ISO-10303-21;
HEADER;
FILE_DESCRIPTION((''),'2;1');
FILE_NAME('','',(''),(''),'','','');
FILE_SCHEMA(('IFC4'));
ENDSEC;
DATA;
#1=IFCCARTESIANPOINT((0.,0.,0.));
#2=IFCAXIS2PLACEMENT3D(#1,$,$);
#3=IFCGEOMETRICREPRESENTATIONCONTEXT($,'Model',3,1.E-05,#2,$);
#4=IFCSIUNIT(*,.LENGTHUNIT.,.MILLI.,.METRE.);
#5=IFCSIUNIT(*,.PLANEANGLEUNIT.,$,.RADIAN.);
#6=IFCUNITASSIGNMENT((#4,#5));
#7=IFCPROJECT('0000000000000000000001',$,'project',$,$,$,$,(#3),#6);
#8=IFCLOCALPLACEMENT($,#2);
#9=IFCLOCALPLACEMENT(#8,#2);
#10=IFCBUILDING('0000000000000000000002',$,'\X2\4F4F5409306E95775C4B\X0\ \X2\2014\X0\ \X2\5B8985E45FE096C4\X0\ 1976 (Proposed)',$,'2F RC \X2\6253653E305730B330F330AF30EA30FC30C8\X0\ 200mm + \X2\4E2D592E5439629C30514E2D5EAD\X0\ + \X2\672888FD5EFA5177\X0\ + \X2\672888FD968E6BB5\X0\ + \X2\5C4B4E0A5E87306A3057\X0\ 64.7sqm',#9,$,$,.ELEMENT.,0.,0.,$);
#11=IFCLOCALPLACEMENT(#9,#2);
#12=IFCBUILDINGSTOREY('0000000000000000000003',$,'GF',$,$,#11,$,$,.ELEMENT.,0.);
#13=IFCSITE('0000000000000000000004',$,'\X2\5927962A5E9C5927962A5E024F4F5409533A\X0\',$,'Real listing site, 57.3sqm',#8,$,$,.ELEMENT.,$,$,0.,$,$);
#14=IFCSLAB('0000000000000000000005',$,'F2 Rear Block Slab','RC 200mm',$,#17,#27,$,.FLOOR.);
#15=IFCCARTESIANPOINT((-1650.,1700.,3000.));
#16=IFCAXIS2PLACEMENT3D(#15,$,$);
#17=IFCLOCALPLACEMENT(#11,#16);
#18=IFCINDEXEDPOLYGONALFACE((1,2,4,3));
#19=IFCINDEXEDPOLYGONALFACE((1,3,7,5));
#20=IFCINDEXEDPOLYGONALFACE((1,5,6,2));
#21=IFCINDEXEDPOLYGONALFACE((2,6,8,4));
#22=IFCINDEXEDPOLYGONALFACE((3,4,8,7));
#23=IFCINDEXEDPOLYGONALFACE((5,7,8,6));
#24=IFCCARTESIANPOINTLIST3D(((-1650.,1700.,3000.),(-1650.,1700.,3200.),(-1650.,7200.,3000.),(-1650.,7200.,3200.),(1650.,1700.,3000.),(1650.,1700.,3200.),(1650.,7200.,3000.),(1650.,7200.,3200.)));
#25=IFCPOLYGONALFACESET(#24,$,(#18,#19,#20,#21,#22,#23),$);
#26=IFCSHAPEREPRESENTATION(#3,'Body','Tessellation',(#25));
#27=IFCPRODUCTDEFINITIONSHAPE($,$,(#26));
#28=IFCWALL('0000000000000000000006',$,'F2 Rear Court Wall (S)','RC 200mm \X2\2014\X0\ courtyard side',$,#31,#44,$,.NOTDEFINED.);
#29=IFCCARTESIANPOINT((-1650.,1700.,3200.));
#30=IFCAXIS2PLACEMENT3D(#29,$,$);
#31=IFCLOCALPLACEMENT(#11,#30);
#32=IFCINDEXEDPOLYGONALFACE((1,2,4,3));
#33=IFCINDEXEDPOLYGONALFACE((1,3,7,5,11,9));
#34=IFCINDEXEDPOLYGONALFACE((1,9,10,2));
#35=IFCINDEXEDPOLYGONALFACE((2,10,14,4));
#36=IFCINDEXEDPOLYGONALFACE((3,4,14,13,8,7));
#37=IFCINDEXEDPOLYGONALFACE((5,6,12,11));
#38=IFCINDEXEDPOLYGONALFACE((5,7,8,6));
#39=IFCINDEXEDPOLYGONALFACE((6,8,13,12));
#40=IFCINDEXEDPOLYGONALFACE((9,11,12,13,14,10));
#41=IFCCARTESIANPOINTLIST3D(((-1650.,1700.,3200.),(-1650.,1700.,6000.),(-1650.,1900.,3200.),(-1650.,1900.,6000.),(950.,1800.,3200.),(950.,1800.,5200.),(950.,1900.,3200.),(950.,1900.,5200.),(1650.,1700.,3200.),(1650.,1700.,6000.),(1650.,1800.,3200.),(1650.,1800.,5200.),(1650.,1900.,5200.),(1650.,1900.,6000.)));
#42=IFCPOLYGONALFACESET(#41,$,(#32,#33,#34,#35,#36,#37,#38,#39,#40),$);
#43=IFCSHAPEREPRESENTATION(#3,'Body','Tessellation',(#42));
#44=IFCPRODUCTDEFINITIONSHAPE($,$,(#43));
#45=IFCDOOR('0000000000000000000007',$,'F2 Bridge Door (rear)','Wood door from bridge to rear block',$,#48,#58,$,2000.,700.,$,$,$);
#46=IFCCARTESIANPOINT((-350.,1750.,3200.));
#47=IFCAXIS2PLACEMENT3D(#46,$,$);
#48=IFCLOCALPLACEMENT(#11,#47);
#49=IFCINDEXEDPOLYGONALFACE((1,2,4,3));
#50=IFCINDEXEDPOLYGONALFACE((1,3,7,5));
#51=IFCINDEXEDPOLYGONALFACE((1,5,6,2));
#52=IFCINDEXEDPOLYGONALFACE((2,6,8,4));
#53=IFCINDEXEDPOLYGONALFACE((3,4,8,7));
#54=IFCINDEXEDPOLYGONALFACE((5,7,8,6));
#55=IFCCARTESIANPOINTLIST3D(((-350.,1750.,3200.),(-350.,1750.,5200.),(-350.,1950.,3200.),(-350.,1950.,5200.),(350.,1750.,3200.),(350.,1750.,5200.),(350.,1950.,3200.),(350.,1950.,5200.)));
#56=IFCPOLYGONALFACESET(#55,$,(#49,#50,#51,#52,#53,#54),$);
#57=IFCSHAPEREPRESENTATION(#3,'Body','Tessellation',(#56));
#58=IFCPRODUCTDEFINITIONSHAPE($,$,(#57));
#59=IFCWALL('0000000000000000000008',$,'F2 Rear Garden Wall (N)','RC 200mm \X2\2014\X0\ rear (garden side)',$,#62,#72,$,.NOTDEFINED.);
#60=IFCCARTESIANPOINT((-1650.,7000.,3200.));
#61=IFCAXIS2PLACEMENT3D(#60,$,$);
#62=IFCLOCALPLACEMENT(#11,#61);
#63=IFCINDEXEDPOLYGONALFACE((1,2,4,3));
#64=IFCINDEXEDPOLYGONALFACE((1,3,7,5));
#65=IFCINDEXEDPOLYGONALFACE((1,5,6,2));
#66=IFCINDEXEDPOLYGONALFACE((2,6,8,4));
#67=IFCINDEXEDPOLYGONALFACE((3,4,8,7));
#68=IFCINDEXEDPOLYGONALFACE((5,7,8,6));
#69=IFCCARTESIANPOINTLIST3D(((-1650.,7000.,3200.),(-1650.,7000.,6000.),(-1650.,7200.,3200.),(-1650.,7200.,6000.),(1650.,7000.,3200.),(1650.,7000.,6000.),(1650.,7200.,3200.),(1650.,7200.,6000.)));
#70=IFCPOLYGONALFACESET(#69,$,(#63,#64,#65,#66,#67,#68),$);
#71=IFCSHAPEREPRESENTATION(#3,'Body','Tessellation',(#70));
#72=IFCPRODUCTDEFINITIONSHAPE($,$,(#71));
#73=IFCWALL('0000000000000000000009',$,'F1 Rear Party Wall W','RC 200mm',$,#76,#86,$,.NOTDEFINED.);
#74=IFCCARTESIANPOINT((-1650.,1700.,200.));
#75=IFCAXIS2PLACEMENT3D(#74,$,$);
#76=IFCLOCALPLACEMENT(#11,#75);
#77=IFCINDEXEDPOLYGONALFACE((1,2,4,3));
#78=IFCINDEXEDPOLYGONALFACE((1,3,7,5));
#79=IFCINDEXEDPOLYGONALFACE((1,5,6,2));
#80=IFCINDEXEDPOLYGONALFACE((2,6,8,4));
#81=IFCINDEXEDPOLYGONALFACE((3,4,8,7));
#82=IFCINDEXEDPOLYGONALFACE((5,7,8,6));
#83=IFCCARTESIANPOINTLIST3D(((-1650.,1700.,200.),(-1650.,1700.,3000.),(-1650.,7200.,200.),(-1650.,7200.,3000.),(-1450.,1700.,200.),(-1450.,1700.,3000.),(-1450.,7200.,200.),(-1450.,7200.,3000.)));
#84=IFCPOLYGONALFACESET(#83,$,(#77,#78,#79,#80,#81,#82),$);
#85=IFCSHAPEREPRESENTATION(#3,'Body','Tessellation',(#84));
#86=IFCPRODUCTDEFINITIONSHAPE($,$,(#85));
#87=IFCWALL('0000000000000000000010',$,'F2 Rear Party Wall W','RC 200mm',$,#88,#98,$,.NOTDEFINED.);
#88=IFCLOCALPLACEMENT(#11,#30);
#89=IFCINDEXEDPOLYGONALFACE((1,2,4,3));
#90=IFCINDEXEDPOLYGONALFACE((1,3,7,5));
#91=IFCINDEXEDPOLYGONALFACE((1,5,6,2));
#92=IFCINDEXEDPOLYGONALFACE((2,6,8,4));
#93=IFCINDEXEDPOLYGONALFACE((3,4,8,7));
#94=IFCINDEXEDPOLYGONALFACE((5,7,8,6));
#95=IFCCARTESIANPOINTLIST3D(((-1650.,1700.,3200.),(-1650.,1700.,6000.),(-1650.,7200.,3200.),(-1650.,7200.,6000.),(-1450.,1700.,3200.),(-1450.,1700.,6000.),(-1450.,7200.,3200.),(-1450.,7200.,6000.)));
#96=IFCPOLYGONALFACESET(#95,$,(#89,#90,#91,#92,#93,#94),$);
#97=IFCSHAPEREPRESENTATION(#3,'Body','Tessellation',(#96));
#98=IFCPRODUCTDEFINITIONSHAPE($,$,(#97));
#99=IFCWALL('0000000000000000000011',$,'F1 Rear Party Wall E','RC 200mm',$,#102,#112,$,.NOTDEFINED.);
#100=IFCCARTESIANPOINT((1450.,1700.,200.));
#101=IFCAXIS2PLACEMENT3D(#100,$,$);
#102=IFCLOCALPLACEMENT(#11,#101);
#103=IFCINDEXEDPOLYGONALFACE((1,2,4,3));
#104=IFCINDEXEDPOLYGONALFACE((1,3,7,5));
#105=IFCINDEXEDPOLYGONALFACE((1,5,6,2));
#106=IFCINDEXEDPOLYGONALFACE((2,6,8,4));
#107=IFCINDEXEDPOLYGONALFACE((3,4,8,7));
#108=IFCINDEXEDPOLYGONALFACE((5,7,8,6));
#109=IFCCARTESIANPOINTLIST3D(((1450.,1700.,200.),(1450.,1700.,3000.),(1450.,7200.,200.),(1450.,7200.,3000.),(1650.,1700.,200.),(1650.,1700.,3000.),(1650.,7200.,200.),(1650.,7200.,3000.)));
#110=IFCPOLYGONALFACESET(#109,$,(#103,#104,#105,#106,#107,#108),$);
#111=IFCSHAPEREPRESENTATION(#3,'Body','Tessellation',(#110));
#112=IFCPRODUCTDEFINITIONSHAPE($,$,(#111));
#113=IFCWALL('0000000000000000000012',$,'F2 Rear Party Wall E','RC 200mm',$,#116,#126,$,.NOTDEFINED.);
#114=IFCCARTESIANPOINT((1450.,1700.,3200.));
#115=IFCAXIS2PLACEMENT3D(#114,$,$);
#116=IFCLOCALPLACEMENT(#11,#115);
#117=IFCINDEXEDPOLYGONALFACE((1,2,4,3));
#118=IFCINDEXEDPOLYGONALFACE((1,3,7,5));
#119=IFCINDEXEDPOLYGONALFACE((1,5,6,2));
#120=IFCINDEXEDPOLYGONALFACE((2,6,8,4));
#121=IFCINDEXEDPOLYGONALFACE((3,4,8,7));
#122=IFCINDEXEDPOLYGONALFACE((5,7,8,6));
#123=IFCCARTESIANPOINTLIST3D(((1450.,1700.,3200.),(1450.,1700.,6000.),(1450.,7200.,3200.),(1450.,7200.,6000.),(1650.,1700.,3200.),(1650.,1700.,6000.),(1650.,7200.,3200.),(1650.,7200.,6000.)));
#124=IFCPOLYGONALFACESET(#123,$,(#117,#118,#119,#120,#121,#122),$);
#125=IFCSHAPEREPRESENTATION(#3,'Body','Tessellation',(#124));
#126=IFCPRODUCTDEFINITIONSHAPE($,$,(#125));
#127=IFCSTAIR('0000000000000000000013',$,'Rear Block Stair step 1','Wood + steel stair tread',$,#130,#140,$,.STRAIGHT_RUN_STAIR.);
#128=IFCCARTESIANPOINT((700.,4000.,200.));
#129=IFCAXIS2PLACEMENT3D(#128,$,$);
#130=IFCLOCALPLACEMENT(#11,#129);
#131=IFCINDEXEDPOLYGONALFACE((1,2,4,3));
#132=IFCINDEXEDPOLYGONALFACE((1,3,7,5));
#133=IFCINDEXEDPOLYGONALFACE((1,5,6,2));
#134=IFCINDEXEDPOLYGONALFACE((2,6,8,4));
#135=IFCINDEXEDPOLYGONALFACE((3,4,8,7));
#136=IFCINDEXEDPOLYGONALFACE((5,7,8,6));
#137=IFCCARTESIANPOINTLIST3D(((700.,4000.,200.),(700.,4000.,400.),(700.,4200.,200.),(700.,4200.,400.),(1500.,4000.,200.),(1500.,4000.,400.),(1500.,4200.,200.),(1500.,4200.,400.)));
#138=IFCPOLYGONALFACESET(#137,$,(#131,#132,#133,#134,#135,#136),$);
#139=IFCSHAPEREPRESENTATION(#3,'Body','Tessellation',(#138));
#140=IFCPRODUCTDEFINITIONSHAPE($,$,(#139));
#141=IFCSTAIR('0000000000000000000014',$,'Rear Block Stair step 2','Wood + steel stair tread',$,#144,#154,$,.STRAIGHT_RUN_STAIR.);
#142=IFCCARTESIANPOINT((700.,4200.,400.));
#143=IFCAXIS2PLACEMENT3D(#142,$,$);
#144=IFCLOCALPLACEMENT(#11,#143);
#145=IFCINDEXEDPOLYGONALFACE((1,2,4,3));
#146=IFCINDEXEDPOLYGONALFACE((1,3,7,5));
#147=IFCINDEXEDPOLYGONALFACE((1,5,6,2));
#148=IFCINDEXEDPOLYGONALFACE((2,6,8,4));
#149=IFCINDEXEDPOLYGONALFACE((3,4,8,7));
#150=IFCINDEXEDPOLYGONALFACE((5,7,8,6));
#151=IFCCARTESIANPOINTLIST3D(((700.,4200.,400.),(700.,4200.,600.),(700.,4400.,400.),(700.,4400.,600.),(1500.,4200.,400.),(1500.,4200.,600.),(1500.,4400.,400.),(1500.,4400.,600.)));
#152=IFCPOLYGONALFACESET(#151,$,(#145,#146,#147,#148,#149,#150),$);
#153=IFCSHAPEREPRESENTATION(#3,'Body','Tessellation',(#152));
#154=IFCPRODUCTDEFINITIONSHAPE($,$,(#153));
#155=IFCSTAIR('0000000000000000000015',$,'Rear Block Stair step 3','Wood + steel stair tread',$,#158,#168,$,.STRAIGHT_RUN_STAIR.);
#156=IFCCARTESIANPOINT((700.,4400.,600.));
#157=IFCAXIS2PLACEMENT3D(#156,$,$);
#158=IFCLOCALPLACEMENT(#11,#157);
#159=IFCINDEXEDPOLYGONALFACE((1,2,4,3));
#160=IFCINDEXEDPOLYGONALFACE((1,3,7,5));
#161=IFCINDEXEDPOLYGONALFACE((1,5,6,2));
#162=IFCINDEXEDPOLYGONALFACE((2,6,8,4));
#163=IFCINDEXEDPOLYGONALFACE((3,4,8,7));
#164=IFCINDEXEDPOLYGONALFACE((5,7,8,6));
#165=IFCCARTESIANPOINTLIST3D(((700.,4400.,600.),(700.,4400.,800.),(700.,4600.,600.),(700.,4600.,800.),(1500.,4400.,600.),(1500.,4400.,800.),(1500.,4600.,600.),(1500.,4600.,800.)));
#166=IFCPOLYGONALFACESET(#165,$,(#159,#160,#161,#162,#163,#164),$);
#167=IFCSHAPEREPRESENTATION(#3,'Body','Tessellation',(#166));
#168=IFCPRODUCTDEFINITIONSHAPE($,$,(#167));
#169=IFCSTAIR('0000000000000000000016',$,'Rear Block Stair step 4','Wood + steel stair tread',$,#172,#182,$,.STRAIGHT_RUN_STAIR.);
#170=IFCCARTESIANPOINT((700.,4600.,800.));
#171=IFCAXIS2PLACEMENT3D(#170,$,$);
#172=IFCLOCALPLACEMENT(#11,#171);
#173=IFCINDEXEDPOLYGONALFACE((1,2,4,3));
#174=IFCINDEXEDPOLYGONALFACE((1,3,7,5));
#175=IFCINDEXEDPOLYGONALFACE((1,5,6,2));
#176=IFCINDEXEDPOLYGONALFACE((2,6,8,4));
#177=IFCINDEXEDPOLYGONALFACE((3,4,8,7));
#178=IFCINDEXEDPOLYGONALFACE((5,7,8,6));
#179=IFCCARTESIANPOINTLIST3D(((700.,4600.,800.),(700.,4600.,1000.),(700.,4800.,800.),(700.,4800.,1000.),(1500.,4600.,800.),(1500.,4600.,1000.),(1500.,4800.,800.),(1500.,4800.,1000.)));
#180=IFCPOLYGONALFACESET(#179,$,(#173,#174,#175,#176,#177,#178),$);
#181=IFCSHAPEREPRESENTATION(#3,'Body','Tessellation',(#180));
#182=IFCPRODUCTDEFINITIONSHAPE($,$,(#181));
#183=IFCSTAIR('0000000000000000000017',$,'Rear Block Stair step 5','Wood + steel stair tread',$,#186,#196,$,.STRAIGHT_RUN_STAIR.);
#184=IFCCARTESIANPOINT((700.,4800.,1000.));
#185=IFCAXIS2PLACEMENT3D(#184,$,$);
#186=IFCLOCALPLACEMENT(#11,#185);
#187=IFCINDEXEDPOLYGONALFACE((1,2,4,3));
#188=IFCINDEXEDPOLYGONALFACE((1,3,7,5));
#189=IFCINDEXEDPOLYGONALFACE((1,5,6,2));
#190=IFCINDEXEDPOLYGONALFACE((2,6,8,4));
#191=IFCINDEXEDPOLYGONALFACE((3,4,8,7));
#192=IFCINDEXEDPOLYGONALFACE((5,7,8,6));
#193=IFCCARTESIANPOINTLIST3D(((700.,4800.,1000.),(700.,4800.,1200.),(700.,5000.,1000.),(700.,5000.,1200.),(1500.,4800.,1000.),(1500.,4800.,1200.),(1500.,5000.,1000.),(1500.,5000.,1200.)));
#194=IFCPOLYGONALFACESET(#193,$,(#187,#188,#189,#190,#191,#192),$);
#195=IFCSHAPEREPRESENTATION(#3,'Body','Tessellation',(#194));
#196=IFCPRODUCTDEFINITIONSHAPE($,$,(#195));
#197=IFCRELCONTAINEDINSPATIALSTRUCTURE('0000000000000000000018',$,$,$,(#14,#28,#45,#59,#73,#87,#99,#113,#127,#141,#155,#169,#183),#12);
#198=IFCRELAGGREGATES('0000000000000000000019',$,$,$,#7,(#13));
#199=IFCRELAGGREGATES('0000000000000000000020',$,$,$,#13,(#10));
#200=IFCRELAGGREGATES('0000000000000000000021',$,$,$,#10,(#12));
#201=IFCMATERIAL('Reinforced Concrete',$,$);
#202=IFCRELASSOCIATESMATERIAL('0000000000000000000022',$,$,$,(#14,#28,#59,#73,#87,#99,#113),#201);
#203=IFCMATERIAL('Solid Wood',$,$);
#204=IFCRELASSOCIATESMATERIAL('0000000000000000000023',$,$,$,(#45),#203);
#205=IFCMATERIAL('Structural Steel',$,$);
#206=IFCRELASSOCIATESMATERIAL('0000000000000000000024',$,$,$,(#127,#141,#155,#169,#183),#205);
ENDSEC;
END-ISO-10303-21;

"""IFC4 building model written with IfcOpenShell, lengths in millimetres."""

from ifc_helpers import new_model, si_unit, frame, frame_2d, origin, place, context, project, spatial, rectangle, extrude, material, element, fill, save


model = new_model("IFC4")

# Units and contexts
model_context = context("Model", 3, precision=1e-05, world=origin())
ifc_project = project(units=[si_unit("LENGTHUNIT", "METRE", prefix="MILLI"), si_unit("PLANEANGLEUNIT", "RADIAN")], contexts=[model_context])

# Site, building, storey
site_placement = place(None, origin())
site = spatial("IfcSite", under=ifc_project, at=site_placement, Name="大阪府大阪市住吉区", ObjectType="Real listing site, 57.3sqm", CompositionType="ELEMENT", RefElevation=0.0)
building_placement = place(site_placement, origin())
building = spatial("IfcBuilding", under=site, at=building_placement, Name="住吉の長屋 — 安藤忠雄 1976 (Proposed)", ObjectType="2F RC 打放しコンクリート 200mm + 中央吹抜け中庭 + 木製建具 + 木製階段 + 屋上庇なし 64.7sqm", CompositionType="ELEMENT", ElevationOfRefHeight=0.0, ElevationOfTerrain=0.0)
storey_placement = place(building_placement, origin())
storey = spatial("IfcBuildingStorey", under=building, at=storey_placement, Name="GF", CompositionType="ELEMENT", Elevation=0.0)

# Slab
ifc_material_1 = material(Name="Reinforced Concrete")
slab_1_placement = place(storey_placement, frame((-1650.0, 1700.0, 3000.0)))
element("IfcSlab", 1, at=slab_1_placement, inside=storey, material=ifc_material_1, Name="F2 Rear Block Slab", Description="RC 200mm", PredefinedType="FLOOR", context=model_context, shape_type="SweptSolid", body=[
    extrude(rectangle(XDim=3300.0, YDim=5500.0, at=frame_2d((1650.0, 2750.0))), frame((-1650.0, 1700.0, 3000.0)), (0.0, 0.0, 1.0), 200.0),
])

# Wall, opening, door
ifc_material_2 = material(Name="Solid Wood")
wall_1_placement = place(storey_placement, frame((-1650.0, 1700.0, 3200.0)))
wall_1 = element("IfcWall", 2, at=wall_1_placement, inside=storey, material=ifc_material_1, Name="F2 Rear Court Wall (S)", Description="RC 200mm — courtyard side", PredefinedType="NOTDEFINED", context=model_context, shape_type="SweptSolid", body=[
    extrude(rectangle(XDim=3300.0, YDim=200.0, at=frame_2d((1650.0, 100.0))), frame((-1650.0, 1700.0, 3200.0)), (0.0, 0.0, 1.0), 2800.0),
])
opening_1_placement = place(storey_placement, frame((-350.0, 1750.0, 3200.0)))
opening_1 = element("IfcOpeningElement", 3, at=opening_1_placement, cuts=wall_1, PredefinedType="NOTDEFINED", context=model_context, shape_type="SweptSolid", body=[
    extrude(rectangle(XDim=700.0, YDim=200.0, at=frame_2d((350.0, 100.0))), frame((-350.0, 1750.0, 3200.0)), (0.0, 0.0, 1.0), 2000.0),
])
door_1_placement = place(storey_placement, frame((-350.0, 1750.0, 3200.0)))
door_1 = element("IfcDoor", 4, at=door_1_placement, inside=storey, material=ifc_material_2, Name="F2 Bridge Door (rear)", Description="Wood door from bridge to rear block", OverallHeight=2000.0, OverallWidth=700.0, context=model_context, shape_type="SweptSolid", body=[
    extrude(rectangle(XDim=700.0, YDim=200.0, at=frame_2d((350.0, 100.0))), frame((-350.0, 1750.0, 3200.0)), (0.0, 0.0, 1.0), 2000.0),
])
fill(opening_1, door_1)

# Walls
wall_2_placement = place(storey_placement, frame((-1650.0, 7000.0, 3200.0)))
element("IfcWall", 5, at=wall_2_placement, inside=storey, material=ifc_material_1, Name="F2 Rear Garden Wall (N)", Description="RC 200mm — rear (garden side)", PredefinedType="NOTDEFINED", context=model_context, shape_type="SweptSolid", body=[
    extrude(rectangle(XDim=3300.0, YDim=200.0, at=frame_2d((1650.0, 100.0))), frame((-1650.0, 7000.0, 3200.0)), (0.0, 0.0, 1.0), 2800.0),
])
wall_3_placement = place(storey_placement, frame((-1650.0, 1700.0, 200.0)))
element("IfcWall", 6, at=wall_3_placement, inside=storey, material=ifc_material_1, Name="F1 Rear Party Wall W", Description="RC 200mm", PredefinedType="NOTDEFINED", context=model_context, shape_type="SweptSolid", body=[
    extrude(rectangle(XDim=200.0, YDim=5500.0, at=frame_2d((100.0, 2750.0))), frame((-1650.0, 1700.0, 200.0)), (0.0, 0.0, 1.0), 2800.0),
])
wall_4_placement = place(storey_placement, frame((-1650.0, 1700.0, 3200.0)))
element("IfcWall", 7, at=wall_4_placement, inside=storey, material=ifc_material_1, Name="F2 Rear Party Wall W", Description="RC 200mm", PredefinedType="NOTDEFINED", context=model_context, shape_type="SweptSolid", body=[
    extrude(rectangle(XDim=200.0, YDim=5500.0, at=frame_2d((100.0, 2750.0))), frame((-1650.0, 1700.0, 3200.0)), (0.0, 0.0, 1.0), 2800.0),
])
wall_5_placement = place(storey_placement, frame((1450.0, 1700.0, 200.0)))
element("IfcWall", 8, at=wall_5_placement, inside=storey, material=ifc_material_1, Name="F1 Rear Party Wall E", Description="RC 200mm", PredefinedType="NOTDEFINED", context=model_context, shape_type="SweptSolid", body=[
    extrude(rectangle(XDim=200.0, YDim=5500.0, at=frame_2d((100.0, 2750.0))), frame((1450.0, 1700.0, 200.0)), (0.0, 0.0, 1.0), 2800.0),
])
wall_6_placement = place(storey_placement, frame((1450.0, 1700.0, 3200.0)))
element("IfcWall", 9, at=wall_6_placement, inside=storey, material=ifc_material_1, Name="F2 Rear Party Wall E", Description="RC 200mm", PredefinedType="NOTDEFINED", context=model_context, shape_type="SweptSolid", body=[
    extrude(rectangle(XDim=200.0, YDim=5500.0, at=frame_2d((100.0, 2750.0))), frame((1450.0, 1700.0, 3200.0)), (0.0, 0.0, 1.0), 2800.0),
])

# Stairs
ifc_material_3 = material(Name="Structural Steel")
stair_1_placement = place(storey_placement, frame((700.0, 4000.0, 200.0)))
element("IfcStair", 10, at=stair_1_placement, inside=storey, material=ifc_material_3, Name="Rear Block Stair step 1", Description="Wood + steel stair tread", PredefinedType="STRAIGHT_RUN_STAIR", context=model_context, shape_type="SweptSolid", body=[
    extrude(rectangle(XDim=800.0, YDim=200.0, at=frame_2d((400.0, 100.0))), frame((700.0, 4000.0, 200.0)), (0.0, 0.0, 1.0), 200.0),
])
stair_2_placement = place(storey_placement, frame((700.0, 4200.0, 400.0)))
element("IfcStair", 11, at=stair_2_placement, inside=storey, material=ifc_material_3, Name="Rear Block Stair step 2", Description="Wood + steel stair tread", PredefinedType="STRAIGHT_RUN_STAIR", context=model_context, shape_type="SweptSolid", body=[
    extrude(rectangle(XDim=800.0, YDim=200.0, at=frame_2d((400.0, 100.0))), frame((700.0, 4200.0, 400.0)), (0.0, 0.0, 1.0), 200.0),
])
stair_3_placement = place(storey_placement, frame((700.0, 4400.0, 600.0)))
element("IfcStair", 12, at=stair_3_placement, inside=storey, material=ifc_material_3, Name="Rear Block Stair step 3", Description="Wood + steel stair tread", PredefinedType="STRAIGHT_RUN_STAIR", context=model_context, shape_type="SweptSolid", body=[
    extrude(rectangle(XDim=800.0, YDim=200.0, at=frame_2d((400.0, 100.0))), frame((700.0, 4400.0, 600.0)), (0.0, 0.0, 1.0), 200.0),
])
stair_4_placement = place(storey_placement, frame((700.0, 4600.0, 800.0)))
element("IfcStair", 13, at=stair_4_placement, inside=storey, material=ifc_material_3, Name="Rear Block Stair step 4", Description="Wood + steel stair tread", PredefinedType="STRAIGHT_RUN_STAIR", context=model_context, shape_type="SweptSolid", body=[
    extrude(rectangle(XDim=800.0, YDim=200.0, at=frame_2d((400.0, 100.0))), frame((700.0, 4600.0, 800.0)), (0.0, 0.0, 1.0), 200.0),
])
stair_5_placement = place(storey_placement, frame((700.0, 4800.0, 1000.0)))
element("IfcStair", 14, at=stair_5_placement, inside=storey, material=ifc_material_3, Name="Rear Block Stair step 5", Description="Wood + steel stair tread", PredefinedType="STRAIGHT_RUN_STAIR", context=model_context, shape_type="SweptSolid", body=[
    extrude(rectangle(XDim=800.0, YDim=200.0, at=frame_2d((400.0, 100.0))), frame((700.0, 4800.0, 1000.0)), (0.0, 0.0, 1.0), 200.0),
])

save(model, "model.ifc")
